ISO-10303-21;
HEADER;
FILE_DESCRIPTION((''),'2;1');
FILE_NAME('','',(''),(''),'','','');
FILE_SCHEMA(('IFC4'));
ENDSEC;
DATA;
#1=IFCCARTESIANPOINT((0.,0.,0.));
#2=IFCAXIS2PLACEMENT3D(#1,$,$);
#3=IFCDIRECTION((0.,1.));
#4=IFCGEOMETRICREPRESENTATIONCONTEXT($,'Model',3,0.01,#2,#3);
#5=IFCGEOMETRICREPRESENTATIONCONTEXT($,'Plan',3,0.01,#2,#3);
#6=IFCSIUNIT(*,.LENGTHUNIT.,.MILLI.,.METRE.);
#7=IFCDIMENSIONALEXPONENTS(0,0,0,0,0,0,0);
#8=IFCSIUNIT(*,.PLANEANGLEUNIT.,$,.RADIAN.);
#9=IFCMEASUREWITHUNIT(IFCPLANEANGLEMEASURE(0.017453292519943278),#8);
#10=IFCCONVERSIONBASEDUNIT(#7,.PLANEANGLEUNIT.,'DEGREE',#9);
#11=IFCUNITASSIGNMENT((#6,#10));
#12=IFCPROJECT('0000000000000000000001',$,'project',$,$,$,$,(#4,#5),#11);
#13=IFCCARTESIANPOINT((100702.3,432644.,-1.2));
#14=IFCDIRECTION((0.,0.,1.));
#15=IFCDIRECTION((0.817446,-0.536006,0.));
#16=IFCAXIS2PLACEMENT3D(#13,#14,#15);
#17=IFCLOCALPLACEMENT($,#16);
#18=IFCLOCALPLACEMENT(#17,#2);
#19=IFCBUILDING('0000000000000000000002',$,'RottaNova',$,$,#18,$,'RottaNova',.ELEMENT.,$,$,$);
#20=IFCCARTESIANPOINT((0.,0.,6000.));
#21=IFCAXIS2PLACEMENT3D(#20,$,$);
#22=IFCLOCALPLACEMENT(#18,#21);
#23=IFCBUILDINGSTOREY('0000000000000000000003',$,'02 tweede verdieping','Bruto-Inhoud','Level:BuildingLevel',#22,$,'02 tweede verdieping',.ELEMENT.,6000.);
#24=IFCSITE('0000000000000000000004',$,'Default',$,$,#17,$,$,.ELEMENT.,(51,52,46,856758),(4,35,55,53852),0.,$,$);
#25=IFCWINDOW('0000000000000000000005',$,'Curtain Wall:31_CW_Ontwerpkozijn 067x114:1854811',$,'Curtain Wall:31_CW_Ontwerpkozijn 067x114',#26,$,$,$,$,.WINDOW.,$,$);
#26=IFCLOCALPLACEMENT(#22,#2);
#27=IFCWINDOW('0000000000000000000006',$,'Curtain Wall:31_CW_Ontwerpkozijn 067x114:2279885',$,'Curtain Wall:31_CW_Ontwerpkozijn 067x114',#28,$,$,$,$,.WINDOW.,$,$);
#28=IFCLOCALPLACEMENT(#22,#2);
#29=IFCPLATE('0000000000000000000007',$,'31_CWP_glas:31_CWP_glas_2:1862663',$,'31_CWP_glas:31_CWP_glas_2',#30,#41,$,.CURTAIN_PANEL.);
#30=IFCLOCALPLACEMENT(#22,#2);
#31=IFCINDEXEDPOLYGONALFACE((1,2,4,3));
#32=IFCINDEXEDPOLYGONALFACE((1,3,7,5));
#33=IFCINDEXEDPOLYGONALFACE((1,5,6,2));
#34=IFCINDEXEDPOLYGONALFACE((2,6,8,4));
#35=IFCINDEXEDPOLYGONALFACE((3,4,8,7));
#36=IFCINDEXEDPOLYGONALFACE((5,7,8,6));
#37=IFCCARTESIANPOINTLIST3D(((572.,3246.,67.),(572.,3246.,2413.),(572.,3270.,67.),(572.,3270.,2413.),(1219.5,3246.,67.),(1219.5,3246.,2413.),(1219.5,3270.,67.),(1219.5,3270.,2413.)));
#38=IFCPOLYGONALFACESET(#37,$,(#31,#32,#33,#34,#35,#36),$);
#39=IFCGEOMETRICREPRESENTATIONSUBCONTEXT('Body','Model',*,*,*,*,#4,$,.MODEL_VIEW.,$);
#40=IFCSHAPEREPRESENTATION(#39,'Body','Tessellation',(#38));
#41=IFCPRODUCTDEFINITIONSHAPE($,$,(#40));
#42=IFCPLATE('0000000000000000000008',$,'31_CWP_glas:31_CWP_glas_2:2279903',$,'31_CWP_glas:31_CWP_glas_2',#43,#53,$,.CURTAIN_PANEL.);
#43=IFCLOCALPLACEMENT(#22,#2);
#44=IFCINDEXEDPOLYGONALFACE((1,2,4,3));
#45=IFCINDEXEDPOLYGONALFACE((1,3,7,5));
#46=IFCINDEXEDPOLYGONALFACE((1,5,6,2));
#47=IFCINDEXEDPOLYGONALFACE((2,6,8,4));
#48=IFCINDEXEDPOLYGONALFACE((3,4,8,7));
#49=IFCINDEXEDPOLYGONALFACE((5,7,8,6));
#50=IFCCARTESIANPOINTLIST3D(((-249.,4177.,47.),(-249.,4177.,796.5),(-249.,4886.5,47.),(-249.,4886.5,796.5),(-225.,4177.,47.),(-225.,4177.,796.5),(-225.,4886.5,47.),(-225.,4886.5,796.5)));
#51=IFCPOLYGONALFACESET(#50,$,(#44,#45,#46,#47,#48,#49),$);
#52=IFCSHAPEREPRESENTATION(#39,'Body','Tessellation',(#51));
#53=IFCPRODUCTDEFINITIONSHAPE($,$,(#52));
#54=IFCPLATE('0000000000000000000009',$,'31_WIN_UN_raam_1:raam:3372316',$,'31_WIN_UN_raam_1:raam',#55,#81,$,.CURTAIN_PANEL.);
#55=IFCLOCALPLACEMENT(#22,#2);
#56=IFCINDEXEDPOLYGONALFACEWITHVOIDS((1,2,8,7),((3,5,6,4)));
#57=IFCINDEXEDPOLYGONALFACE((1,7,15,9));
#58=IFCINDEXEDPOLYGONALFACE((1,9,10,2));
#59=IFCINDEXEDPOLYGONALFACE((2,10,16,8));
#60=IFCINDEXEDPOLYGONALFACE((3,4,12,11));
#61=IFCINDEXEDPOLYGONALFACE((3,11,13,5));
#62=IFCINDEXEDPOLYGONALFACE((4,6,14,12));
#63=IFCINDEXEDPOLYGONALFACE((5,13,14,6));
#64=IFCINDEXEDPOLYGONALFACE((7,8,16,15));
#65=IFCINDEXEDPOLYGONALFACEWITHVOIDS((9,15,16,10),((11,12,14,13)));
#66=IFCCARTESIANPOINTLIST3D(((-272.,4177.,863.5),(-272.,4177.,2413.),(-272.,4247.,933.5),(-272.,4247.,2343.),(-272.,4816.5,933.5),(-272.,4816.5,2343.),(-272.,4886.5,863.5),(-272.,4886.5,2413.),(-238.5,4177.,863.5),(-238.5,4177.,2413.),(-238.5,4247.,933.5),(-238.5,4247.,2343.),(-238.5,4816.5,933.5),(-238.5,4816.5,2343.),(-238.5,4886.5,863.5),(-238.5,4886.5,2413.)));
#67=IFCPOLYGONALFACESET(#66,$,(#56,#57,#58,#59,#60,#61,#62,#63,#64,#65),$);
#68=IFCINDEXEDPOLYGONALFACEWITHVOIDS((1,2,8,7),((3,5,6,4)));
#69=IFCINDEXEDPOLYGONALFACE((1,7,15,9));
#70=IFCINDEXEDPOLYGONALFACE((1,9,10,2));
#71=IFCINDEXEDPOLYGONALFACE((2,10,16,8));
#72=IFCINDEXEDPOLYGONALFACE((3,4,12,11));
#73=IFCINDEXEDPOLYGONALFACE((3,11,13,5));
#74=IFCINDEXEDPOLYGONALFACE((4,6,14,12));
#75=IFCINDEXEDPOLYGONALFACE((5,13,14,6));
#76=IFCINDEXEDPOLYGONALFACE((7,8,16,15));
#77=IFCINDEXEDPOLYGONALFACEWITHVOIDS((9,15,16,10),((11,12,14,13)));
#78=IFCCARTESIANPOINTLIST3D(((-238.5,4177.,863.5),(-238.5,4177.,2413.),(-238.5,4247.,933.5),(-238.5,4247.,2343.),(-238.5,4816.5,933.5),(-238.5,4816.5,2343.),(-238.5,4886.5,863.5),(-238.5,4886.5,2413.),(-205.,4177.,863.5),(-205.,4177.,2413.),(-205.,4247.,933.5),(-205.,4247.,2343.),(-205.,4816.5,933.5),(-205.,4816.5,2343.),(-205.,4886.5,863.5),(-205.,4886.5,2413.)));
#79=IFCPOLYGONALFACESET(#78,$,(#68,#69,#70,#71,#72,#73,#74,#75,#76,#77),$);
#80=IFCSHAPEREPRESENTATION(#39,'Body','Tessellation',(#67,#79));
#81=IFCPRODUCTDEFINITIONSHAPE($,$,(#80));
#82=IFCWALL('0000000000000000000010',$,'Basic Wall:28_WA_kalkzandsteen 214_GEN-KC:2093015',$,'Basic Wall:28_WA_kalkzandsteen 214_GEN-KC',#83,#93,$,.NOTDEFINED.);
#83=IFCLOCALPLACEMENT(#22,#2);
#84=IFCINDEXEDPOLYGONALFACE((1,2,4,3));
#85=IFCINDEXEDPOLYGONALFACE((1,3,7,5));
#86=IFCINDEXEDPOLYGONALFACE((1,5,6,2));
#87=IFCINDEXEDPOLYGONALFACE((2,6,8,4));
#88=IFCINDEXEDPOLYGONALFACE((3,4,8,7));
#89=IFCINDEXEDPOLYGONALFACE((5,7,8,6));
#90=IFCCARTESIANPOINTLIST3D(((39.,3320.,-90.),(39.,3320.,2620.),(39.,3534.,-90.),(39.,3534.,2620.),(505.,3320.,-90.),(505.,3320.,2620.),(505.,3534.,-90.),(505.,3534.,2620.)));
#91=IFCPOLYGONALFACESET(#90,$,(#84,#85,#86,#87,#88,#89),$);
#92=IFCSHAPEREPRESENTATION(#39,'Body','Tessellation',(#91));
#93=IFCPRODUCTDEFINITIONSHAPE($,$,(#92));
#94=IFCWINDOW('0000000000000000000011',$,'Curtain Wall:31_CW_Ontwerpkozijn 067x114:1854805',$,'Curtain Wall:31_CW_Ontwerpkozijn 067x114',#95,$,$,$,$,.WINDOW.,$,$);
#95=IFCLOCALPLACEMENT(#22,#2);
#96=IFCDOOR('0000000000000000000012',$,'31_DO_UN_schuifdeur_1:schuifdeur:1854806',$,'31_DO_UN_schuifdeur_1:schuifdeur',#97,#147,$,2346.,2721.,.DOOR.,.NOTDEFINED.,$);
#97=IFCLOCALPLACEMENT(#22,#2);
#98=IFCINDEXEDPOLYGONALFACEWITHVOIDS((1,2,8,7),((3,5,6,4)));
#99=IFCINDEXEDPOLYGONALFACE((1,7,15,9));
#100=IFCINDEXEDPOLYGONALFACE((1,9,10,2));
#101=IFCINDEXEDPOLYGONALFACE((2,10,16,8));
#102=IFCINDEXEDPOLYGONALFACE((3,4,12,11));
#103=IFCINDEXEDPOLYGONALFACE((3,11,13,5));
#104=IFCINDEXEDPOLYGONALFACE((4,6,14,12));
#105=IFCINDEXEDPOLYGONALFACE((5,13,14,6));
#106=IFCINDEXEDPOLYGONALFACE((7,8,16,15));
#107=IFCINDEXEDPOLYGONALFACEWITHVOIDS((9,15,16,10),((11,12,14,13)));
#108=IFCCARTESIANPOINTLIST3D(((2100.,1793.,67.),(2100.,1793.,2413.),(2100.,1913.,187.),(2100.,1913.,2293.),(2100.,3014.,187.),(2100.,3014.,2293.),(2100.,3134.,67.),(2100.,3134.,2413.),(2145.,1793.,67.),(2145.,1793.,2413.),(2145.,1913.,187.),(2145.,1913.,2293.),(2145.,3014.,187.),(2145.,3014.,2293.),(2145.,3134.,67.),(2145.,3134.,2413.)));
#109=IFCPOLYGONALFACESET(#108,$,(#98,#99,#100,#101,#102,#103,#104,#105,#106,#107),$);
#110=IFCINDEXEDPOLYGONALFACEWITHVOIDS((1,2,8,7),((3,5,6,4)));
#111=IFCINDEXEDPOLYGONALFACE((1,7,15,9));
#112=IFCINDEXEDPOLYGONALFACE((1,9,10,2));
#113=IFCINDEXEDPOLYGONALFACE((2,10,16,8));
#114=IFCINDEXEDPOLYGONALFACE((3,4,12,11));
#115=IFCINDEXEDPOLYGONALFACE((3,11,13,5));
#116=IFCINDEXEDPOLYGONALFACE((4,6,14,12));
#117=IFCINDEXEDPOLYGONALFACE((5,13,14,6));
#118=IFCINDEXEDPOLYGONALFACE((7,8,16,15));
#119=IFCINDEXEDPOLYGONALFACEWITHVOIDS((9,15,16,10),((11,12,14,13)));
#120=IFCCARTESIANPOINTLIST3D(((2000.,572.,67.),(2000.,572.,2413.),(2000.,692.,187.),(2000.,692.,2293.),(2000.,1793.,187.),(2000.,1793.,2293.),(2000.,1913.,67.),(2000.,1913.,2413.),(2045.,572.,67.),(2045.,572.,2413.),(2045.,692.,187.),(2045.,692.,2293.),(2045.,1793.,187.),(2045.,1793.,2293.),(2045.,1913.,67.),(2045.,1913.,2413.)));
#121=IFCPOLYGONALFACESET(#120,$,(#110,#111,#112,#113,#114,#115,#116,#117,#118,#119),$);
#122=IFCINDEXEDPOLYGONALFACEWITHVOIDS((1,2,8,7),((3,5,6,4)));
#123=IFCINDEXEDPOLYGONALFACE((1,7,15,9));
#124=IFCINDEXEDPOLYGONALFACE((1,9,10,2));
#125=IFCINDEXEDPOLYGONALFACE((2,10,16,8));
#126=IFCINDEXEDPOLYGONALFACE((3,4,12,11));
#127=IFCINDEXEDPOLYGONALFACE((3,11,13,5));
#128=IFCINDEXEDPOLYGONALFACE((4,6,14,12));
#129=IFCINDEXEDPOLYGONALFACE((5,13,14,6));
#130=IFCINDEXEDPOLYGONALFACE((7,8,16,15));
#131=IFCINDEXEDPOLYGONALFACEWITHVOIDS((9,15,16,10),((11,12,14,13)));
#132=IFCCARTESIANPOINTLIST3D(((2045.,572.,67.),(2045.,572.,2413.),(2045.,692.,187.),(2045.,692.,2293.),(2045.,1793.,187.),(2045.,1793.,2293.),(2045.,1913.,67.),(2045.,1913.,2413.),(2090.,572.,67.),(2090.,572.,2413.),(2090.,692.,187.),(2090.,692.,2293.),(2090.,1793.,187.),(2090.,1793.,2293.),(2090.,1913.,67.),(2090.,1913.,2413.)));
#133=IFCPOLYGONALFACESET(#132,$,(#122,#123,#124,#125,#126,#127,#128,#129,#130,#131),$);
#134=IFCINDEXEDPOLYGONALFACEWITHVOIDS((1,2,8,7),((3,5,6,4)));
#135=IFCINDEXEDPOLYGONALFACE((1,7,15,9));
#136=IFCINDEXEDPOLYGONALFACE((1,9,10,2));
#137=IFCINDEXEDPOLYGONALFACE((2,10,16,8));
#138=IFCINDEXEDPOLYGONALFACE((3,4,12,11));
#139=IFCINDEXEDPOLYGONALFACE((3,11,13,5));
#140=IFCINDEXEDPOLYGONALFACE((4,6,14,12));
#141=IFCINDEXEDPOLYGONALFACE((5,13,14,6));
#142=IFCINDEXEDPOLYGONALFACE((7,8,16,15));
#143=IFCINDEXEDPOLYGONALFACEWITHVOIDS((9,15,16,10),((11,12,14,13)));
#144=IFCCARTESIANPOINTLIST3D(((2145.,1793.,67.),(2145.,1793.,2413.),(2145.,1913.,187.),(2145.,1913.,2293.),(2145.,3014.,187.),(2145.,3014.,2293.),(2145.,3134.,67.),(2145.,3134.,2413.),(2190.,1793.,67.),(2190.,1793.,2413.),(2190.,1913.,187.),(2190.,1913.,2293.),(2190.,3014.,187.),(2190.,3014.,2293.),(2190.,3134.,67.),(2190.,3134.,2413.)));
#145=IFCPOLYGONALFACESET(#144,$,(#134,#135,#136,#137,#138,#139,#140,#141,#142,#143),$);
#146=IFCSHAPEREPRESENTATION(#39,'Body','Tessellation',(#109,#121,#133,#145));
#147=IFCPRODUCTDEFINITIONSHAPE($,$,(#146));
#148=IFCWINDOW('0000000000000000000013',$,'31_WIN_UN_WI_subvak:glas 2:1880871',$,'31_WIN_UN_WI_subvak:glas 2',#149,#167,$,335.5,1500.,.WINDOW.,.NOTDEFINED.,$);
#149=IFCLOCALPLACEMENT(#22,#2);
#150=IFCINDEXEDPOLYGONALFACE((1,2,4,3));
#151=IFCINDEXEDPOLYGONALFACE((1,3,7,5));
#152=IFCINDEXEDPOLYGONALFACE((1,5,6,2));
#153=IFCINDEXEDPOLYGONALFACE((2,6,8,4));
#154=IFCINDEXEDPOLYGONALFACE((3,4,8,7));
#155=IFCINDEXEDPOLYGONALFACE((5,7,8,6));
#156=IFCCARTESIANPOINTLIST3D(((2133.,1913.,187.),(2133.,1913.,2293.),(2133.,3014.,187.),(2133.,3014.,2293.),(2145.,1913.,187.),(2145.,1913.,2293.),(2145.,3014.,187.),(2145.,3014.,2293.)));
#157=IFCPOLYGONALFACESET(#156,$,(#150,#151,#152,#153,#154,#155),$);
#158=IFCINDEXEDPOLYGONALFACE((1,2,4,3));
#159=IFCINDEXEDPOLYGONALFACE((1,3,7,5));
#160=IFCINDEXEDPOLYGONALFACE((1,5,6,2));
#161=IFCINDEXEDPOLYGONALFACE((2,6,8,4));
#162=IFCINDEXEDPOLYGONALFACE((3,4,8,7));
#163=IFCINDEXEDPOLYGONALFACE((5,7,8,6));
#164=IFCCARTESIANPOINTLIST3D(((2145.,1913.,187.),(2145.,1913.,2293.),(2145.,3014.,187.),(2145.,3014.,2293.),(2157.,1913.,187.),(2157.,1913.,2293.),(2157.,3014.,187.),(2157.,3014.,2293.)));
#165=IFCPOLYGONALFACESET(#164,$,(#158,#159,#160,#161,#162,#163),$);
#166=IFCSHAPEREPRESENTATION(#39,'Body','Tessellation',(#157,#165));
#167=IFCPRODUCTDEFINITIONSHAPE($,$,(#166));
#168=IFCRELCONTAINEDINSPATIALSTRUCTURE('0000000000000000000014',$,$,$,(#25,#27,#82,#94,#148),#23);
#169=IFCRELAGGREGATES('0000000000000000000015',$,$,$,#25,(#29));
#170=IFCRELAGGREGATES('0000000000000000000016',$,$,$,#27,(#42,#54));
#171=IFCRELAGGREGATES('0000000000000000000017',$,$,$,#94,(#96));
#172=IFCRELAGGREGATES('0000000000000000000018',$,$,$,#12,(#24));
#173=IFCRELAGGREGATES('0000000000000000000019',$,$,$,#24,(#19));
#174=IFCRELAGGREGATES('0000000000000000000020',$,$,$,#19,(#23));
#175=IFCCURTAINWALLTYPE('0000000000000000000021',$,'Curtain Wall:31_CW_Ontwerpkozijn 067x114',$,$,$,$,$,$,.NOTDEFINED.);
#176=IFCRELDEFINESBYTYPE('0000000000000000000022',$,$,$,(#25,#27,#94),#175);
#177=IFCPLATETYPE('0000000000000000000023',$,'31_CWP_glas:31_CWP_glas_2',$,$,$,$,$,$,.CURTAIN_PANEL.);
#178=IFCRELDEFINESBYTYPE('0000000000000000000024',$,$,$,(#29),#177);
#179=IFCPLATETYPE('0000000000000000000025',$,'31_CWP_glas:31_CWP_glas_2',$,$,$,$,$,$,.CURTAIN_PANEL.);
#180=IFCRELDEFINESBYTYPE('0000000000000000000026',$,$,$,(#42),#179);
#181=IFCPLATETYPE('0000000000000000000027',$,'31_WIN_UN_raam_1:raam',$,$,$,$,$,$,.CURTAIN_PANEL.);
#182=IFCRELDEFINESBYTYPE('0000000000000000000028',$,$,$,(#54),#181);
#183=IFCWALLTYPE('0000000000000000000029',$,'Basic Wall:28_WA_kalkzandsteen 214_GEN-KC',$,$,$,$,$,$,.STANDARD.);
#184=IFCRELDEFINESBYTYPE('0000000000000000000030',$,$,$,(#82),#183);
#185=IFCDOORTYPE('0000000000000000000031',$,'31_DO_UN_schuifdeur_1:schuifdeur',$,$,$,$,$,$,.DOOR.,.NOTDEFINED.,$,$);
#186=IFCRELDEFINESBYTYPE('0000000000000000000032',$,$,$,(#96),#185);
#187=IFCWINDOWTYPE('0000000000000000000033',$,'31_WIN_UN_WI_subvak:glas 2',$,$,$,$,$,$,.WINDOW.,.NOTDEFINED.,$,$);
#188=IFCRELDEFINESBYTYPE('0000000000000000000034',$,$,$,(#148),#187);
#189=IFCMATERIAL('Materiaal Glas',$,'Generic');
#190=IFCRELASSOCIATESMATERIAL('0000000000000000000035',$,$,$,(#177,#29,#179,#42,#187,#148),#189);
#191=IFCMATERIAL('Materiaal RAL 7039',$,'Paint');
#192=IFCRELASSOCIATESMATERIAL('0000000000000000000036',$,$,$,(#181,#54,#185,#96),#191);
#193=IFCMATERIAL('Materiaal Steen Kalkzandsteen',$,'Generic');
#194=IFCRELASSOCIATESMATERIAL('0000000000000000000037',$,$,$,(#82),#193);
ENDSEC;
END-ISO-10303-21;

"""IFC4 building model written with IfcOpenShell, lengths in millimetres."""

from ifc_helpers import new_model, entity, si_unit, converted_unit, direction, frame, origin, place, context, subcontext, project, spatial, indexed_curve, outline, extrude, source, transform, mapped, material, type_object, type_shapes, element, aggregate, save


model = new_model("IFC4")

# Units and contexts
model_context = context("Model", 3, precision=0.01, world=origin(), true_north=direction((0.0, 1.0)))
plan_context = context("Plan", 3, precision=0.01, world=origin(), true_north=direction((0.0, 1.0)))
body_context = subcontext(model_context, "Body", "Model", "MODEL_VIEW")
ifc_project = project(units=[si_unit("LENGTHUNIT", "METRE", prefix="MILLI"), converted_unit("PLANEANGLEUNIT", "DEGREE", entity("IfcPlaneAngleMeasure", 0.017453292519943278), si_unit("PLANEANGLEUNIT", "RADIAN"), dimensions=[0, 0, 0, 0, 0, 0, 0])], contexts=[model_context, plan_context])

# Site, building, storey
site_placement = place(None, frame((100702.3, 432644.0, -1.2), z_axis=(0.0, 0.0, 1.0), x_axis=(0.817446, -0.536006, 0.0)))
site = spatial("IfcSite", under=ifc_project, at=site_placement, Name="Default", CompositionType="ELEMENT", RefLatitude=(51, 52, 46, 856758), RefLongitude=(4, 35, 55, 53852), RefElevation=0.0)
building_placement = place(site_placement, origin())
building = spatial("IfcBuilding", under=site, at=building_placement, Name="RottaNova", LongName="RottaNova", CompositionType="ELEMENT")
storey_placement = place(building_placement, frame((0.0, 0.0, 6000.0)))
storey = spatial("IfcBuildingStorey", under=building, at=storey_placement, Name="02 tweede verdieping", Description="Bruto-Inhoud", ObjectType="Level:BuildingLevel", LongName="02 tweede verdieping", CompositionType="ELEMENT", Elevation=6000.0)

# Windows
curtain_wall_type = type_object("IfcCurtainWallType", Name="Curtain Wall:31_CW_Ontwerpkozijn 067x114", PredefinedType="NOTDEFINED")
window_1_placement = place(storey_placement, frame((0.0, 0.0, -6000.0)))
window_1 = element("IfcWindow", 1, at=window_1_placement, inside=storey, type_object=curtain_wall_type, Name="Curtain Wall:31_CW_Ontwerpkozijn 067x114:1854811", ObjectType="Curtain Wall:31_CW_Ontwerpkozijn 067x114", PredefinedType="WINDOW")
ifc_material_1 = material(Name="Materiaal RAL 7039", Category="Paint")
window_2_placement = place(storey_placement, frame((0.0, 0.0, -6000.0)))
window_2 = element("IfcWindow", 2, at=window_2_placement, inside=storey, type_object=curtain_wall_type, Name="Curtain Wall:31_CW_Ontwerpkozijn 067x114:2279885", ObjectType="Curtain Wall:31_CW_Ontwerpkozijn 067x114", PredefinedType="WINDOW")

# Plates
ifc_material_2 = material(Name="Materiaal Glas", Category="Generic")
plate_type_1 = type_object("IfcPlateType", Name="31_CWP_glas:31_CWP_glas_2", PredefinedType="CURTAIN_PANEL", material=ifc_material_2)
shared_shape_1 = source(origin(), body_context, "Body", "SweptSolid", [
    extrude(outline(indexed_curve([(-12.0, -323.8), (12.0, -323.8), (12.0, 323.8), (-12.0, 323.8), (-12.0, -323.8)], self_intersect=False)), frame((0.0, 57.0, 0.0), z_axis=(0.0, 0.0, 1.0), x_axis=(0.0, 1.0, 0.0)), (0.0, 0.0, 1.0), 2346.0),
])
type_shapes(plate_type_1, [shared_shape_1])
plate_1_placement = place(window_1_placement, frame((895.8, 3315.0, 6067.0), z_axis=(0.0, 0.0, 1.0), x_axis=(-1.0, 0.0, 0.0)))
plate_1 = element("IfcPlate", 3, at=plate_1_placement, type_object=plate_type_1, material=ifc_material_2, Name="31_CWP_glas:31_CWP_glas_2:1862663", ObjectType="31_CWP_glas:31_CWP_glas_2", PredefinedType="CURTAIN_PANEL", context=body_context, shape_type="MappedRepresentation", body=[
    mapped(shared_shape_1, transform((0.0, 0.0, 0.0), scale=1.0)),
])
aggregate(window_1, [plate_1])
plate_type_2 = type_object("IfcPlateType", Name="31_CWP_glas:31_CWP_glas_2", PredefinedType="CURTAIN_PANEL", material=ifc_material_2)
shared_shape_2 = source(origin(), body_context, "Body", "SweptSolid", [
    extrude(outline(indexed_curve([(-12.0, -354.8), (12.0, -354.8), (12.0, 354.8), (-12.0, 354.8), (-12.0, -354.8)], self_intersect=False)), frame((0.0, -57.0, 0.0), z_axis=(0.0, 0.0, 1.0), x_axis=(0.0, 1.0, 0.0)), (0.0, 0.0, 1.0), 749.5),
])
type_shapes(plate_type_2, [shared_shape_2])
plate_2_placement = place(window_2_placement, frame((-180.0, 4531.7, 6047.0), z_axis=(0.0, 0.0, 1.0), x_axis=(0.0, -1.0, 0.0)))
plate_2 = element("IfcPlate", 4, at=plate_2_placement, type_object=plate_type_2, material=ifc_material_2, Name="31_CWP_glas:31_CWP_glas_2:2279903", ObjectType="31_CWP_glas:31_CWP_glas_2", PredefinedType="CURTAIN_PANEL", context=body_context, shape_type="MappedRepresentation", body=[
    mapped(shared_shape_2, transform((0.0, 0.0, 0.0), scale=1.0)),
])
plate_type_3 = type_object("IfcPlateType", Name="31_WIN_UN_raam_1:raam", PredefinedType="CURTAIN_PANEL", material=ifc_material_1)
shared_shape_3 = source(origin(), body_context, "Body", "SweptSolid", [
    extrude(outline(indexed_curve([(-354.7, -774.7), (354.7, -774.7), (354.7, 774.7), (-354.7, 774.7), (-354.7, -774.7)], self_intersect=False), holes=[indexed_curve([(-284.7, 704.7), (284.7, 704.7), (284.7, -704.8), (-284.7, -704.8), (-284.7, 704.7)], self_intersect=False)]), frame((0.0, -92.0, 774.8), z_axis=(0.0, 1.0, 0.0), x_axis=(1.0, 0.0, 0.0)), (0.0, 0.0, 1.0), 33.5),
    extrude(outline(indexed_curve([(-354.7, -774.7), (354.7, -774.7), (354.7, 774.7), (-354.7, 774.7), (-354.7, -774.7)], self_intersect=False), holes=[indexed_curve([(-284.7, 704.7), (284.7, 704.7), (284.7, -704.8), (-284.7, -704.8), (-284.7, 704.7)], self_intersect=False)]), frame((0.0, -58.5, 774.8), z_axis=(0.0, 1.0, 0.0), x_axis=(1.0, 0.0, 0.0)), (0.0, 0.0, 1.0), 33.5),
])
type_shapes(plate_type_3, [shared_shape_3])
plate_3_placement = place(window_2_placement, frame((-180.0, 4531.7, 6863.5), z_axis=(0.0, 0.0, 1.0), x_axis=(0.0, -1.0, 0.0)))
plate_3 = element("IfcPlate", 5, at=plate_3_placement, type_object=plate_type_3, material=ifc_material_1, Name="31_WIN_UN_raam_1:raam:3372316", ObjectType="31_WIN_UN_raam_1:raam", PredefinedType="CURTAIN_PANEL", context=body_context, shape_type="MappedRepresentation", body=[
    mapped(shared_shape_3, transform((0.0, 0.0, 0.0), scale=1.0)),
])
aggregate(window_2, [plate_2, plate_3])

# Wall
ifc_material_3 = material(Name="Materiaal Steen Kalkzandsteen", Category="Generic")
wall_type_1 = type_object("IfcWallType", Name="Basic Wall:28_WA_kalkzandsteen 214_GEN-KC", PredefinedType="STANDARD")
wall_1_placement = place(storey_placement, frame((39.0, 3427.0, -90.0)))
element("IfcWall", 6, at=wall_1_placement, inside=storey, type_object=wall_type_1, material=ifc_material_3, Name="Basic Wall:28_WA_kalkzandsteen 214_GEN-KC:2093015", ObjectType="Basic Wall:28_WA_kalkzandsteen 214_GEN-KC", PredefinedType="NOTDEFINED", context=body_context, shape_type="SweptSolid", body=[
    extrude(outline(indexed_curve([(466.0, 107.0), (0.0, 107.0), (0.0, -107.0), (466.0, -107.0), (466.0, 107.0)], self_intersect=False)), origin(), (0.0, 0.0, 1.0), 2710.0),
])

# Window, door
window_3_placement = place(storey_placement, frame((0.0, 0.0, -6000.0)))
window_3 = element("IfcWindow", 7, at=window_3_placement, inside=storey, type_object=curtain_wall_type, Name="Curtain Wall:31_CW_Ontwerpkozijn 067x114:1854805", ObjectType="Curtain Wall:31_CW_Ontwerpkozijn 067x114", PredefinedType="WINDOW")
door_type = type_object("IfcDoorType", Name="31_DO_UN_schuifdeur_1:schuifdeur", OperationType="NOTDEFINED", PredefinedType="DOOR", material=ifc_material_1)
shared_shape_4 = source(origin(), body_context, "Body", "SweptSolid", [
    extrude(outline(indexed_curve([(-670.5, -1173.0), (670.5, -1173.0), (670.5, 1173.0), (-670.5, 1173.0), (-670.5, -1173.0)], self_intersect=False), holes=[indexed_curve([(-550.5, -1053.0), (-550.5, 1053.0), (550.5, 1053.0), (550.5, -1053.0), (-550.5, -1053.0)], self_intersect=False)]), frame((610.5, 45.0, 1173.0), z_axis=(0.0, 1.0, 0.0), x_axis=(1.0, 0.0, 0.0)), (0.0, 0.0, 1.0), 45.0),
    extrude(outline(indexed_curve([(-670.5, -1173.0), (670.5, -1173.0), (670.5, 1173.0), (-670.5, 1173.0), (-670.5, -1173.0)], self_intersect=False), holes=[indexed_curve([(-550.5, -1053.0), (-550.5, 1053.0), (550.5, 1053.0), (550.5, -1053.0), (-550.5, -1053.0)], self_intersect=False)]), frame((-610.5, 145.0, 1173.0), z_axis=(0.0, 1.0, 0.0), x_axis=(1.0, 0.0, 0.0)), (0.0, 0.0, 1.0), 45.0),
    extrude(outline(indexed_curve([(-670.5, -1173.0), (670.5, -1173.0), (670.5, 1173.0), (-670.5, 1173.0), (-670.5, -1173.0)], self_intersect=False), holes=[indexed_curve([(-550.5, -1053.0), (-550.5, 1053.0), (550.5, 1053.0), (550.5, -1053.0), (-550.5, -1053.0)], self_intersect=False)]), frame((-610.5, 100.0, 1173.0), z_axis=(0.0, 1.0, 0.0), x_axis=(1.0, 0.0, 0.0)), (0.0, 0.0, 1.0), 45.0),
    extrude(outline(indexed_curve([(-670.5, -1173.0), (670.5, -1173.0), (670.5, 1173.0), (-670.5, 1173.0), (-670.5, -1173.0)], self_intersect=False), holes=[indexed_curve([(-550.5, -1053.0), (-550.5, 1053.0), (550.5, 1053.0), (550.5, -1053.0), (-550.5, -1053.0)], self_intersect=False)]), frame((610.5, 0.0, 1173.0), z_axis=(0.0, 1.0, 0.0), x_axis=(1.0, 0.0, 0.0)), (0.0, 0.0, 1.0), 45.0),
])
type_shapes(door_type, [shared_shape_4])
door_placement = place(window_3_placement, frame((2190.0, 1853.0, 6067.0), z_axis=(0.0, 0.0, 1.0), x_axis=(0.0, 1.0, 0.0)))
door = element("IfcDoor", 8, at=door_placement, type_object=door_type, material=ifc_material_1, Name="31_DO_UN_schuifdeur_1:schuifdeur:1854806", ObjectType="31_DO_UN_schuifdeur_1:schuifdeur", OperationType="NOTDEFINED", OverallHeight=2346.0, OverallWidth=2721.0, PredefinedType="DOOR", context=body_context, shape_type="MappedRepresentation", body=[
    mapped(shared_shape_4, transform((0.0, 0.0, 0.0), scale=1.0)),
])
aggregate(window_3, [door])

# Window
window_type = type_object("IfcWindowType", Name="31_WIN_UN_WI_subvak:glas 2", PartitioningType="NOTDEFINED", PredefinedType="WINDOW", material=ifc_material_2)
shared_shape_5 = source(origin(), body_context, "Body", "SweptSolid", [
    extrude(outline(indexed_curve([(-6.0, -550.5), (6.0, -550.5), (6.0, 550.5), (-6.0, 550.5), (-6.0, -550.5)], self_intersect=False)), frame((0.0, 6.0, 0.0), z_axis=(0.0, 0.0, 1.0), x_axis=(0.0, -1.0, 0.0)), (0.0, 0.0, 1.0), 2106.0),
    extrude(outline(indexed_curve([(-6.0, -550.5), (6.0, -550.5), (6.0, 550.5), (-6.0, 550.5), (-6.0, -550.5)], self_intersect=False)), frame((0.0, -6.0, 0.0), z_axis=(0.0, 0.0, 1.0), x_axis=(0.0, -1.0, 0.0)), (0.0, 0.0, 1.0), 2106.0),
])
type_shapes(window_type, [shared_shape_5])
window_4_placement = place(storey_placement, frame((2145.0, 2463.5, 187.0), z_axis=(0.0, 0.0, 1.0), x_axis=(0.0, 1.0, 0.0)))
element("IfcWindow", 9, at=window_4_placement, inside=storey, type_object=window_type, material=ifc_material_2, Name="31_WIN_UN_WI_subvak:glas 2:1880871", ObjectType="31_WIN_UN_WI_subvak:glas 2", OverallHeight=335.5, OverallWidth=1500.0, PartitioningType="NOTDEFINED", PredefinedType="WINDOW", context=body_context, shape_type="MappedRepresentation", body=[
    mapped(shared_shape_5, transform((0.0, 0.0, 0.0), scale=1.0)),
])

save(model, "model.ifc")
